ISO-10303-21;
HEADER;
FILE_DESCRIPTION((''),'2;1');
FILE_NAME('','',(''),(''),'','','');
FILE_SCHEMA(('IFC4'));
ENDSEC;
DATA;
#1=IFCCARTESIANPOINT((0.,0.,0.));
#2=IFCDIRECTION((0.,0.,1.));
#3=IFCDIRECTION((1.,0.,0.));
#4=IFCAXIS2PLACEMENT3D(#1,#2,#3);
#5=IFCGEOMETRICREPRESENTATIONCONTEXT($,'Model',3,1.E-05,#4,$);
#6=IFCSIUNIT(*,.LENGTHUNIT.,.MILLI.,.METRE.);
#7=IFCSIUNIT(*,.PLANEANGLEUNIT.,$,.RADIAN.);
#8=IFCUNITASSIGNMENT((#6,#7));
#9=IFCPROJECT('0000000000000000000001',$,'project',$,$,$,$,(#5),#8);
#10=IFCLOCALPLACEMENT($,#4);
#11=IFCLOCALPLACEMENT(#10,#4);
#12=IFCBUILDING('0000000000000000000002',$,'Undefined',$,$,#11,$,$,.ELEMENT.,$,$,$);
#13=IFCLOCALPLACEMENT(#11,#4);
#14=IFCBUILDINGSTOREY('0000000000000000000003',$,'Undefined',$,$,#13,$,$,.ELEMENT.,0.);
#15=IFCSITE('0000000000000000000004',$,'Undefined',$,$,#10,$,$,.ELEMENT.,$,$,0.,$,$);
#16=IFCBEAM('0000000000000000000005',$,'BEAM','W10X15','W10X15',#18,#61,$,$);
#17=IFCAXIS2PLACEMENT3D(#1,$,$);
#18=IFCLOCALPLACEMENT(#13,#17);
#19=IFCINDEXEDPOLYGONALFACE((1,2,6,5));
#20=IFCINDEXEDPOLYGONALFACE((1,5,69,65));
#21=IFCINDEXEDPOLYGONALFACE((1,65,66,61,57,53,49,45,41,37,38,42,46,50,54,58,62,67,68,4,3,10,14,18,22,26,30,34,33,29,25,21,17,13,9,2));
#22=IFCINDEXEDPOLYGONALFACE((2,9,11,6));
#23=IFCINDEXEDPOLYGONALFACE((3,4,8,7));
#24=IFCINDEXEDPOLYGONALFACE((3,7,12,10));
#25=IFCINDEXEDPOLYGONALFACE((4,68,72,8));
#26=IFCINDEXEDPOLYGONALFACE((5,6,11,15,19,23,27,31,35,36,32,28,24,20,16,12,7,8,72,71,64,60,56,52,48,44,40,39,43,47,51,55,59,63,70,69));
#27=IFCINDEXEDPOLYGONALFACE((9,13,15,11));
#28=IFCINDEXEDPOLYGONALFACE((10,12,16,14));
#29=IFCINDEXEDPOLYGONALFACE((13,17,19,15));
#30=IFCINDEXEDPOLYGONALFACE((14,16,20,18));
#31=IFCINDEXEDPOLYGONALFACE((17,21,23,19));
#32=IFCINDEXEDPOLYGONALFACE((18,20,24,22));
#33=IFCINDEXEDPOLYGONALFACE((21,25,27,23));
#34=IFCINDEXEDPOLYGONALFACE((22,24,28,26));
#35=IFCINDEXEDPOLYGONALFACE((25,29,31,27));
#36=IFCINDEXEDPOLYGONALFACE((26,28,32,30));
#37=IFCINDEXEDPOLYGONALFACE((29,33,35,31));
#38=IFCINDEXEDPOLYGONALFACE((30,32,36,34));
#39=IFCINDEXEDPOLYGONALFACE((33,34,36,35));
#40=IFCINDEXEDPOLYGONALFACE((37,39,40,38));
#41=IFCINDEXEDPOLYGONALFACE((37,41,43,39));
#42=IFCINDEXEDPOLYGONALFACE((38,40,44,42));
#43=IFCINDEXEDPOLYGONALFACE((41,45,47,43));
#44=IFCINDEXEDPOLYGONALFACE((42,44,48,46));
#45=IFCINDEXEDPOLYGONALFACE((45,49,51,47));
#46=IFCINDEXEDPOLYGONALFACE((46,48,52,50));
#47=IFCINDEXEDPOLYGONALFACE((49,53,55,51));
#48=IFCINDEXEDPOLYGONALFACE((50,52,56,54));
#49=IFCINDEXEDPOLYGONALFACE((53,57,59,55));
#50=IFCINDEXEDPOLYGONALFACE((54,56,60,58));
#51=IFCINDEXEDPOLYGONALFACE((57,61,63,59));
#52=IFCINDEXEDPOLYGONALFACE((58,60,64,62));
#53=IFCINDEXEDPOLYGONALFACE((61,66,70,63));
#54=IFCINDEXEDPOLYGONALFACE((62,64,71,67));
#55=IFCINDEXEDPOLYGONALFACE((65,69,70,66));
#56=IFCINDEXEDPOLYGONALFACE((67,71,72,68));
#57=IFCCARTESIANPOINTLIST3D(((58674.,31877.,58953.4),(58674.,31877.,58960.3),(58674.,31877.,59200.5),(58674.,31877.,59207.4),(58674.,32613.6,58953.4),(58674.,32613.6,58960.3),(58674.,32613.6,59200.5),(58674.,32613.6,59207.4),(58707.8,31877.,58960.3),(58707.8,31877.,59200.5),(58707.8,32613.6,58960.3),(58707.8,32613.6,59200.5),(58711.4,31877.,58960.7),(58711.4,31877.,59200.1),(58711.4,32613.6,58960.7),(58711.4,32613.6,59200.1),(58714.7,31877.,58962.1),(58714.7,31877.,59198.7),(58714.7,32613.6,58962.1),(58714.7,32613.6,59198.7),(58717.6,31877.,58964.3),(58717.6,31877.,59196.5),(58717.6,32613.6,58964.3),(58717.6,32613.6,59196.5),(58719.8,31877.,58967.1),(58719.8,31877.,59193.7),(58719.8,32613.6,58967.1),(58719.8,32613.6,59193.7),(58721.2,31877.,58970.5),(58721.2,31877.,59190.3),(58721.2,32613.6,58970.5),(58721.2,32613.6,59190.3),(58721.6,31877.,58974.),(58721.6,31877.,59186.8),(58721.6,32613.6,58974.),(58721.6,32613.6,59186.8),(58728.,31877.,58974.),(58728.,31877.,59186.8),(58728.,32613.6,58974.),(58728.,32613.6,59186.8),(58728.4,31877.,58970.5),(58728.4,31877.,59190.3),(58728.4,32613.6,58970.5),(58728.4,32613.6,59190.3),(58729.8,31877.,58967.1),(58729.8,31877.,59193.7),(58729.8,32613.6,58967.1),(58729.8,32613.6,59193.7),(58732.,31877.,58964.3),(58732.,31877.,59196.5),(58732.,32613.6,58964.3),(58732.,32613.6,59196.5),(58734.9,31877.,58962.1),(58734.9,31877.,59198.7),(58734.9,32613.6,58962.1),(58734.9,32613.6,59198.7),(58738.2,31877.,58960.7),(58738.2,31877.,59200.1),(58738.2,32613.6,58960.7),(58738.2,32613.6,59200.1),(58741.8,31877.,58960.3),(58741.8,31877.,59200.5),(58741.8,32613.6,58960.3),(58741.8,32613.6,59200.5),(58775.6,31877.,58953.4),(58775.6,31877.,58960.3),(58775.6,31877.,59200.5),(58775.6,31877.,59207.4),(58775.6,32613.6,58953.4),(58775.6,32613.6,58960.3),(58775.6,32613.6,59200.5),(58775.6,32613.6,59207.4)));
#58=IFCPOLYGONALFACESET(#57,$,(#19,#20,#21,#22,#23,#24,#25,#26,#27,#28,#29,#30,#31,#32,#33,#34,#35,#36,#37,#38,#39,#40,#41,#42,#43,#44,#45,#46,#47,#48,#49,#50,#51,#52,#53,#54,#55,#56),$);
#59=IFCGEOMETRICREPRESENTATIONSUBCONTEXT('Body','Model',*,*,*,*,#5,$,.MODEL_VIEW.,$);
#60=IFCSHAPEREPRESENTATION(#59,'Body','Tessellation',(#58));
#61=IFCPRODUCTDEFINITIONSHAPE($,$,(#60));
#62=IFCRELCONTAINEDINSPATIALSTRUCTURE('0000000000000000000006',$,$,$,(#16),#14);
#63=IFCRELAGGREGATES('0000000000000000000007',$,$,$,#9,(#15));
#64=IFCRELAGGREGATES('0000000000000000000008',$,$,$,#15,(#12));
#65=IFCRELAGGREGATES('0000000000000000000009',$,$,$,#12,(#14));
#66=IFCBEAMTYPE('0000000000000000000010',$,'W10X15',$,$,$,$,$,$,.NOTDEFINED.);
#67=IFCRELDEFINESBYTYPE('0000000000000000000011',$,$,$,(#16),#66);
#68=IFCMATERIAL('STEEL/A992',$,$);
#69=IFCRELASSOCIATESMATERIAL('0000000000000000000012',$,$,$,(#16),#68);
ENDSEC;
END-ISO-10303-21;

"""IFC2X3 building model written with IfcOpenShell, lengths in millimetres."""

from ifc_helpers import new_model, si_unit, frame, origin_with_axes, origin_2d_with_axis, place, context, subcontext, project, spatial, i_section, extrude, material, type_object, element, save


model = new_model("IFC2X3")

# Units and contexts
model_context = context("Model", 3, precision=1e-05, world=origin_with_axes())
body_context = subcontext(model_context, "Body", "Model", "MODEL_VIEW")
ifc_project = project(units=[si_unit("LENGTHUNIT", "METRE", prefix="MILLI"), si_unit("PLANEANGLEUNIT", "RADIAN")], contexts=[model_context])

# Site, building, storey
site_placement = place(None, origin_with_axes())
site = spatial("IfcSite", under=ifc_project, at=site_placement, Name="Undefined", CompositionType="ELEMENT", RefElevation=0.0)
building_placement = place(site_placement, origin_with_axes())
building = spatial("IfcBuilding", under=site, at=building_placement, Name="Undefined", CompositionType="ELEMENT")
storey_placement = place(building_placement, origin_with_axes())
storey = spatial("IfcBuildingStorey", under=building, at=storey_placement, Name="Undefined", CompositionType="ELEMENT", Elevation=0.0)

# Beam
ifc_material_1 = material(Name="STEEL/A992")
beam_type_1 = type_object("IfcBeamType", Name="W10X15", PredefinedType="NOTDEFINED")
for number, where, z_axis, x_axis, name in (
    (1, (58724.8, 31877.0, 59080.4), (0.0, 0.0, 1.0), (0.0, 1.0, 0.0), "BEAM"),
):
    element("IfcBeam", number, at=place(storey_placement, frame(where, z_axis=z_axis, x_axis=x_axis)), inside=storey, type_object=beam_type_1, material=ifc_material_1, Name=name, Description="W10X15", ObjectType="W10X15", context=body_context, shape_type="SweptSolid", body=[
        extrude(i_section(OverallWidth=101.6, OverallDepth=254.0, WebThickness=6.3, FlangeThickness=6.9, FilletRadius=13.8, at=origin_2d_with_axis()), frame((736.6, 0.0, 0.0), z_axis=(-1.0, 0.0, 0.0), x_axis=(0.0, -1.0, 0.0)), (0.0, 0.0, 1.0), 736.6),
    ])

save(model, "model.ifc")
